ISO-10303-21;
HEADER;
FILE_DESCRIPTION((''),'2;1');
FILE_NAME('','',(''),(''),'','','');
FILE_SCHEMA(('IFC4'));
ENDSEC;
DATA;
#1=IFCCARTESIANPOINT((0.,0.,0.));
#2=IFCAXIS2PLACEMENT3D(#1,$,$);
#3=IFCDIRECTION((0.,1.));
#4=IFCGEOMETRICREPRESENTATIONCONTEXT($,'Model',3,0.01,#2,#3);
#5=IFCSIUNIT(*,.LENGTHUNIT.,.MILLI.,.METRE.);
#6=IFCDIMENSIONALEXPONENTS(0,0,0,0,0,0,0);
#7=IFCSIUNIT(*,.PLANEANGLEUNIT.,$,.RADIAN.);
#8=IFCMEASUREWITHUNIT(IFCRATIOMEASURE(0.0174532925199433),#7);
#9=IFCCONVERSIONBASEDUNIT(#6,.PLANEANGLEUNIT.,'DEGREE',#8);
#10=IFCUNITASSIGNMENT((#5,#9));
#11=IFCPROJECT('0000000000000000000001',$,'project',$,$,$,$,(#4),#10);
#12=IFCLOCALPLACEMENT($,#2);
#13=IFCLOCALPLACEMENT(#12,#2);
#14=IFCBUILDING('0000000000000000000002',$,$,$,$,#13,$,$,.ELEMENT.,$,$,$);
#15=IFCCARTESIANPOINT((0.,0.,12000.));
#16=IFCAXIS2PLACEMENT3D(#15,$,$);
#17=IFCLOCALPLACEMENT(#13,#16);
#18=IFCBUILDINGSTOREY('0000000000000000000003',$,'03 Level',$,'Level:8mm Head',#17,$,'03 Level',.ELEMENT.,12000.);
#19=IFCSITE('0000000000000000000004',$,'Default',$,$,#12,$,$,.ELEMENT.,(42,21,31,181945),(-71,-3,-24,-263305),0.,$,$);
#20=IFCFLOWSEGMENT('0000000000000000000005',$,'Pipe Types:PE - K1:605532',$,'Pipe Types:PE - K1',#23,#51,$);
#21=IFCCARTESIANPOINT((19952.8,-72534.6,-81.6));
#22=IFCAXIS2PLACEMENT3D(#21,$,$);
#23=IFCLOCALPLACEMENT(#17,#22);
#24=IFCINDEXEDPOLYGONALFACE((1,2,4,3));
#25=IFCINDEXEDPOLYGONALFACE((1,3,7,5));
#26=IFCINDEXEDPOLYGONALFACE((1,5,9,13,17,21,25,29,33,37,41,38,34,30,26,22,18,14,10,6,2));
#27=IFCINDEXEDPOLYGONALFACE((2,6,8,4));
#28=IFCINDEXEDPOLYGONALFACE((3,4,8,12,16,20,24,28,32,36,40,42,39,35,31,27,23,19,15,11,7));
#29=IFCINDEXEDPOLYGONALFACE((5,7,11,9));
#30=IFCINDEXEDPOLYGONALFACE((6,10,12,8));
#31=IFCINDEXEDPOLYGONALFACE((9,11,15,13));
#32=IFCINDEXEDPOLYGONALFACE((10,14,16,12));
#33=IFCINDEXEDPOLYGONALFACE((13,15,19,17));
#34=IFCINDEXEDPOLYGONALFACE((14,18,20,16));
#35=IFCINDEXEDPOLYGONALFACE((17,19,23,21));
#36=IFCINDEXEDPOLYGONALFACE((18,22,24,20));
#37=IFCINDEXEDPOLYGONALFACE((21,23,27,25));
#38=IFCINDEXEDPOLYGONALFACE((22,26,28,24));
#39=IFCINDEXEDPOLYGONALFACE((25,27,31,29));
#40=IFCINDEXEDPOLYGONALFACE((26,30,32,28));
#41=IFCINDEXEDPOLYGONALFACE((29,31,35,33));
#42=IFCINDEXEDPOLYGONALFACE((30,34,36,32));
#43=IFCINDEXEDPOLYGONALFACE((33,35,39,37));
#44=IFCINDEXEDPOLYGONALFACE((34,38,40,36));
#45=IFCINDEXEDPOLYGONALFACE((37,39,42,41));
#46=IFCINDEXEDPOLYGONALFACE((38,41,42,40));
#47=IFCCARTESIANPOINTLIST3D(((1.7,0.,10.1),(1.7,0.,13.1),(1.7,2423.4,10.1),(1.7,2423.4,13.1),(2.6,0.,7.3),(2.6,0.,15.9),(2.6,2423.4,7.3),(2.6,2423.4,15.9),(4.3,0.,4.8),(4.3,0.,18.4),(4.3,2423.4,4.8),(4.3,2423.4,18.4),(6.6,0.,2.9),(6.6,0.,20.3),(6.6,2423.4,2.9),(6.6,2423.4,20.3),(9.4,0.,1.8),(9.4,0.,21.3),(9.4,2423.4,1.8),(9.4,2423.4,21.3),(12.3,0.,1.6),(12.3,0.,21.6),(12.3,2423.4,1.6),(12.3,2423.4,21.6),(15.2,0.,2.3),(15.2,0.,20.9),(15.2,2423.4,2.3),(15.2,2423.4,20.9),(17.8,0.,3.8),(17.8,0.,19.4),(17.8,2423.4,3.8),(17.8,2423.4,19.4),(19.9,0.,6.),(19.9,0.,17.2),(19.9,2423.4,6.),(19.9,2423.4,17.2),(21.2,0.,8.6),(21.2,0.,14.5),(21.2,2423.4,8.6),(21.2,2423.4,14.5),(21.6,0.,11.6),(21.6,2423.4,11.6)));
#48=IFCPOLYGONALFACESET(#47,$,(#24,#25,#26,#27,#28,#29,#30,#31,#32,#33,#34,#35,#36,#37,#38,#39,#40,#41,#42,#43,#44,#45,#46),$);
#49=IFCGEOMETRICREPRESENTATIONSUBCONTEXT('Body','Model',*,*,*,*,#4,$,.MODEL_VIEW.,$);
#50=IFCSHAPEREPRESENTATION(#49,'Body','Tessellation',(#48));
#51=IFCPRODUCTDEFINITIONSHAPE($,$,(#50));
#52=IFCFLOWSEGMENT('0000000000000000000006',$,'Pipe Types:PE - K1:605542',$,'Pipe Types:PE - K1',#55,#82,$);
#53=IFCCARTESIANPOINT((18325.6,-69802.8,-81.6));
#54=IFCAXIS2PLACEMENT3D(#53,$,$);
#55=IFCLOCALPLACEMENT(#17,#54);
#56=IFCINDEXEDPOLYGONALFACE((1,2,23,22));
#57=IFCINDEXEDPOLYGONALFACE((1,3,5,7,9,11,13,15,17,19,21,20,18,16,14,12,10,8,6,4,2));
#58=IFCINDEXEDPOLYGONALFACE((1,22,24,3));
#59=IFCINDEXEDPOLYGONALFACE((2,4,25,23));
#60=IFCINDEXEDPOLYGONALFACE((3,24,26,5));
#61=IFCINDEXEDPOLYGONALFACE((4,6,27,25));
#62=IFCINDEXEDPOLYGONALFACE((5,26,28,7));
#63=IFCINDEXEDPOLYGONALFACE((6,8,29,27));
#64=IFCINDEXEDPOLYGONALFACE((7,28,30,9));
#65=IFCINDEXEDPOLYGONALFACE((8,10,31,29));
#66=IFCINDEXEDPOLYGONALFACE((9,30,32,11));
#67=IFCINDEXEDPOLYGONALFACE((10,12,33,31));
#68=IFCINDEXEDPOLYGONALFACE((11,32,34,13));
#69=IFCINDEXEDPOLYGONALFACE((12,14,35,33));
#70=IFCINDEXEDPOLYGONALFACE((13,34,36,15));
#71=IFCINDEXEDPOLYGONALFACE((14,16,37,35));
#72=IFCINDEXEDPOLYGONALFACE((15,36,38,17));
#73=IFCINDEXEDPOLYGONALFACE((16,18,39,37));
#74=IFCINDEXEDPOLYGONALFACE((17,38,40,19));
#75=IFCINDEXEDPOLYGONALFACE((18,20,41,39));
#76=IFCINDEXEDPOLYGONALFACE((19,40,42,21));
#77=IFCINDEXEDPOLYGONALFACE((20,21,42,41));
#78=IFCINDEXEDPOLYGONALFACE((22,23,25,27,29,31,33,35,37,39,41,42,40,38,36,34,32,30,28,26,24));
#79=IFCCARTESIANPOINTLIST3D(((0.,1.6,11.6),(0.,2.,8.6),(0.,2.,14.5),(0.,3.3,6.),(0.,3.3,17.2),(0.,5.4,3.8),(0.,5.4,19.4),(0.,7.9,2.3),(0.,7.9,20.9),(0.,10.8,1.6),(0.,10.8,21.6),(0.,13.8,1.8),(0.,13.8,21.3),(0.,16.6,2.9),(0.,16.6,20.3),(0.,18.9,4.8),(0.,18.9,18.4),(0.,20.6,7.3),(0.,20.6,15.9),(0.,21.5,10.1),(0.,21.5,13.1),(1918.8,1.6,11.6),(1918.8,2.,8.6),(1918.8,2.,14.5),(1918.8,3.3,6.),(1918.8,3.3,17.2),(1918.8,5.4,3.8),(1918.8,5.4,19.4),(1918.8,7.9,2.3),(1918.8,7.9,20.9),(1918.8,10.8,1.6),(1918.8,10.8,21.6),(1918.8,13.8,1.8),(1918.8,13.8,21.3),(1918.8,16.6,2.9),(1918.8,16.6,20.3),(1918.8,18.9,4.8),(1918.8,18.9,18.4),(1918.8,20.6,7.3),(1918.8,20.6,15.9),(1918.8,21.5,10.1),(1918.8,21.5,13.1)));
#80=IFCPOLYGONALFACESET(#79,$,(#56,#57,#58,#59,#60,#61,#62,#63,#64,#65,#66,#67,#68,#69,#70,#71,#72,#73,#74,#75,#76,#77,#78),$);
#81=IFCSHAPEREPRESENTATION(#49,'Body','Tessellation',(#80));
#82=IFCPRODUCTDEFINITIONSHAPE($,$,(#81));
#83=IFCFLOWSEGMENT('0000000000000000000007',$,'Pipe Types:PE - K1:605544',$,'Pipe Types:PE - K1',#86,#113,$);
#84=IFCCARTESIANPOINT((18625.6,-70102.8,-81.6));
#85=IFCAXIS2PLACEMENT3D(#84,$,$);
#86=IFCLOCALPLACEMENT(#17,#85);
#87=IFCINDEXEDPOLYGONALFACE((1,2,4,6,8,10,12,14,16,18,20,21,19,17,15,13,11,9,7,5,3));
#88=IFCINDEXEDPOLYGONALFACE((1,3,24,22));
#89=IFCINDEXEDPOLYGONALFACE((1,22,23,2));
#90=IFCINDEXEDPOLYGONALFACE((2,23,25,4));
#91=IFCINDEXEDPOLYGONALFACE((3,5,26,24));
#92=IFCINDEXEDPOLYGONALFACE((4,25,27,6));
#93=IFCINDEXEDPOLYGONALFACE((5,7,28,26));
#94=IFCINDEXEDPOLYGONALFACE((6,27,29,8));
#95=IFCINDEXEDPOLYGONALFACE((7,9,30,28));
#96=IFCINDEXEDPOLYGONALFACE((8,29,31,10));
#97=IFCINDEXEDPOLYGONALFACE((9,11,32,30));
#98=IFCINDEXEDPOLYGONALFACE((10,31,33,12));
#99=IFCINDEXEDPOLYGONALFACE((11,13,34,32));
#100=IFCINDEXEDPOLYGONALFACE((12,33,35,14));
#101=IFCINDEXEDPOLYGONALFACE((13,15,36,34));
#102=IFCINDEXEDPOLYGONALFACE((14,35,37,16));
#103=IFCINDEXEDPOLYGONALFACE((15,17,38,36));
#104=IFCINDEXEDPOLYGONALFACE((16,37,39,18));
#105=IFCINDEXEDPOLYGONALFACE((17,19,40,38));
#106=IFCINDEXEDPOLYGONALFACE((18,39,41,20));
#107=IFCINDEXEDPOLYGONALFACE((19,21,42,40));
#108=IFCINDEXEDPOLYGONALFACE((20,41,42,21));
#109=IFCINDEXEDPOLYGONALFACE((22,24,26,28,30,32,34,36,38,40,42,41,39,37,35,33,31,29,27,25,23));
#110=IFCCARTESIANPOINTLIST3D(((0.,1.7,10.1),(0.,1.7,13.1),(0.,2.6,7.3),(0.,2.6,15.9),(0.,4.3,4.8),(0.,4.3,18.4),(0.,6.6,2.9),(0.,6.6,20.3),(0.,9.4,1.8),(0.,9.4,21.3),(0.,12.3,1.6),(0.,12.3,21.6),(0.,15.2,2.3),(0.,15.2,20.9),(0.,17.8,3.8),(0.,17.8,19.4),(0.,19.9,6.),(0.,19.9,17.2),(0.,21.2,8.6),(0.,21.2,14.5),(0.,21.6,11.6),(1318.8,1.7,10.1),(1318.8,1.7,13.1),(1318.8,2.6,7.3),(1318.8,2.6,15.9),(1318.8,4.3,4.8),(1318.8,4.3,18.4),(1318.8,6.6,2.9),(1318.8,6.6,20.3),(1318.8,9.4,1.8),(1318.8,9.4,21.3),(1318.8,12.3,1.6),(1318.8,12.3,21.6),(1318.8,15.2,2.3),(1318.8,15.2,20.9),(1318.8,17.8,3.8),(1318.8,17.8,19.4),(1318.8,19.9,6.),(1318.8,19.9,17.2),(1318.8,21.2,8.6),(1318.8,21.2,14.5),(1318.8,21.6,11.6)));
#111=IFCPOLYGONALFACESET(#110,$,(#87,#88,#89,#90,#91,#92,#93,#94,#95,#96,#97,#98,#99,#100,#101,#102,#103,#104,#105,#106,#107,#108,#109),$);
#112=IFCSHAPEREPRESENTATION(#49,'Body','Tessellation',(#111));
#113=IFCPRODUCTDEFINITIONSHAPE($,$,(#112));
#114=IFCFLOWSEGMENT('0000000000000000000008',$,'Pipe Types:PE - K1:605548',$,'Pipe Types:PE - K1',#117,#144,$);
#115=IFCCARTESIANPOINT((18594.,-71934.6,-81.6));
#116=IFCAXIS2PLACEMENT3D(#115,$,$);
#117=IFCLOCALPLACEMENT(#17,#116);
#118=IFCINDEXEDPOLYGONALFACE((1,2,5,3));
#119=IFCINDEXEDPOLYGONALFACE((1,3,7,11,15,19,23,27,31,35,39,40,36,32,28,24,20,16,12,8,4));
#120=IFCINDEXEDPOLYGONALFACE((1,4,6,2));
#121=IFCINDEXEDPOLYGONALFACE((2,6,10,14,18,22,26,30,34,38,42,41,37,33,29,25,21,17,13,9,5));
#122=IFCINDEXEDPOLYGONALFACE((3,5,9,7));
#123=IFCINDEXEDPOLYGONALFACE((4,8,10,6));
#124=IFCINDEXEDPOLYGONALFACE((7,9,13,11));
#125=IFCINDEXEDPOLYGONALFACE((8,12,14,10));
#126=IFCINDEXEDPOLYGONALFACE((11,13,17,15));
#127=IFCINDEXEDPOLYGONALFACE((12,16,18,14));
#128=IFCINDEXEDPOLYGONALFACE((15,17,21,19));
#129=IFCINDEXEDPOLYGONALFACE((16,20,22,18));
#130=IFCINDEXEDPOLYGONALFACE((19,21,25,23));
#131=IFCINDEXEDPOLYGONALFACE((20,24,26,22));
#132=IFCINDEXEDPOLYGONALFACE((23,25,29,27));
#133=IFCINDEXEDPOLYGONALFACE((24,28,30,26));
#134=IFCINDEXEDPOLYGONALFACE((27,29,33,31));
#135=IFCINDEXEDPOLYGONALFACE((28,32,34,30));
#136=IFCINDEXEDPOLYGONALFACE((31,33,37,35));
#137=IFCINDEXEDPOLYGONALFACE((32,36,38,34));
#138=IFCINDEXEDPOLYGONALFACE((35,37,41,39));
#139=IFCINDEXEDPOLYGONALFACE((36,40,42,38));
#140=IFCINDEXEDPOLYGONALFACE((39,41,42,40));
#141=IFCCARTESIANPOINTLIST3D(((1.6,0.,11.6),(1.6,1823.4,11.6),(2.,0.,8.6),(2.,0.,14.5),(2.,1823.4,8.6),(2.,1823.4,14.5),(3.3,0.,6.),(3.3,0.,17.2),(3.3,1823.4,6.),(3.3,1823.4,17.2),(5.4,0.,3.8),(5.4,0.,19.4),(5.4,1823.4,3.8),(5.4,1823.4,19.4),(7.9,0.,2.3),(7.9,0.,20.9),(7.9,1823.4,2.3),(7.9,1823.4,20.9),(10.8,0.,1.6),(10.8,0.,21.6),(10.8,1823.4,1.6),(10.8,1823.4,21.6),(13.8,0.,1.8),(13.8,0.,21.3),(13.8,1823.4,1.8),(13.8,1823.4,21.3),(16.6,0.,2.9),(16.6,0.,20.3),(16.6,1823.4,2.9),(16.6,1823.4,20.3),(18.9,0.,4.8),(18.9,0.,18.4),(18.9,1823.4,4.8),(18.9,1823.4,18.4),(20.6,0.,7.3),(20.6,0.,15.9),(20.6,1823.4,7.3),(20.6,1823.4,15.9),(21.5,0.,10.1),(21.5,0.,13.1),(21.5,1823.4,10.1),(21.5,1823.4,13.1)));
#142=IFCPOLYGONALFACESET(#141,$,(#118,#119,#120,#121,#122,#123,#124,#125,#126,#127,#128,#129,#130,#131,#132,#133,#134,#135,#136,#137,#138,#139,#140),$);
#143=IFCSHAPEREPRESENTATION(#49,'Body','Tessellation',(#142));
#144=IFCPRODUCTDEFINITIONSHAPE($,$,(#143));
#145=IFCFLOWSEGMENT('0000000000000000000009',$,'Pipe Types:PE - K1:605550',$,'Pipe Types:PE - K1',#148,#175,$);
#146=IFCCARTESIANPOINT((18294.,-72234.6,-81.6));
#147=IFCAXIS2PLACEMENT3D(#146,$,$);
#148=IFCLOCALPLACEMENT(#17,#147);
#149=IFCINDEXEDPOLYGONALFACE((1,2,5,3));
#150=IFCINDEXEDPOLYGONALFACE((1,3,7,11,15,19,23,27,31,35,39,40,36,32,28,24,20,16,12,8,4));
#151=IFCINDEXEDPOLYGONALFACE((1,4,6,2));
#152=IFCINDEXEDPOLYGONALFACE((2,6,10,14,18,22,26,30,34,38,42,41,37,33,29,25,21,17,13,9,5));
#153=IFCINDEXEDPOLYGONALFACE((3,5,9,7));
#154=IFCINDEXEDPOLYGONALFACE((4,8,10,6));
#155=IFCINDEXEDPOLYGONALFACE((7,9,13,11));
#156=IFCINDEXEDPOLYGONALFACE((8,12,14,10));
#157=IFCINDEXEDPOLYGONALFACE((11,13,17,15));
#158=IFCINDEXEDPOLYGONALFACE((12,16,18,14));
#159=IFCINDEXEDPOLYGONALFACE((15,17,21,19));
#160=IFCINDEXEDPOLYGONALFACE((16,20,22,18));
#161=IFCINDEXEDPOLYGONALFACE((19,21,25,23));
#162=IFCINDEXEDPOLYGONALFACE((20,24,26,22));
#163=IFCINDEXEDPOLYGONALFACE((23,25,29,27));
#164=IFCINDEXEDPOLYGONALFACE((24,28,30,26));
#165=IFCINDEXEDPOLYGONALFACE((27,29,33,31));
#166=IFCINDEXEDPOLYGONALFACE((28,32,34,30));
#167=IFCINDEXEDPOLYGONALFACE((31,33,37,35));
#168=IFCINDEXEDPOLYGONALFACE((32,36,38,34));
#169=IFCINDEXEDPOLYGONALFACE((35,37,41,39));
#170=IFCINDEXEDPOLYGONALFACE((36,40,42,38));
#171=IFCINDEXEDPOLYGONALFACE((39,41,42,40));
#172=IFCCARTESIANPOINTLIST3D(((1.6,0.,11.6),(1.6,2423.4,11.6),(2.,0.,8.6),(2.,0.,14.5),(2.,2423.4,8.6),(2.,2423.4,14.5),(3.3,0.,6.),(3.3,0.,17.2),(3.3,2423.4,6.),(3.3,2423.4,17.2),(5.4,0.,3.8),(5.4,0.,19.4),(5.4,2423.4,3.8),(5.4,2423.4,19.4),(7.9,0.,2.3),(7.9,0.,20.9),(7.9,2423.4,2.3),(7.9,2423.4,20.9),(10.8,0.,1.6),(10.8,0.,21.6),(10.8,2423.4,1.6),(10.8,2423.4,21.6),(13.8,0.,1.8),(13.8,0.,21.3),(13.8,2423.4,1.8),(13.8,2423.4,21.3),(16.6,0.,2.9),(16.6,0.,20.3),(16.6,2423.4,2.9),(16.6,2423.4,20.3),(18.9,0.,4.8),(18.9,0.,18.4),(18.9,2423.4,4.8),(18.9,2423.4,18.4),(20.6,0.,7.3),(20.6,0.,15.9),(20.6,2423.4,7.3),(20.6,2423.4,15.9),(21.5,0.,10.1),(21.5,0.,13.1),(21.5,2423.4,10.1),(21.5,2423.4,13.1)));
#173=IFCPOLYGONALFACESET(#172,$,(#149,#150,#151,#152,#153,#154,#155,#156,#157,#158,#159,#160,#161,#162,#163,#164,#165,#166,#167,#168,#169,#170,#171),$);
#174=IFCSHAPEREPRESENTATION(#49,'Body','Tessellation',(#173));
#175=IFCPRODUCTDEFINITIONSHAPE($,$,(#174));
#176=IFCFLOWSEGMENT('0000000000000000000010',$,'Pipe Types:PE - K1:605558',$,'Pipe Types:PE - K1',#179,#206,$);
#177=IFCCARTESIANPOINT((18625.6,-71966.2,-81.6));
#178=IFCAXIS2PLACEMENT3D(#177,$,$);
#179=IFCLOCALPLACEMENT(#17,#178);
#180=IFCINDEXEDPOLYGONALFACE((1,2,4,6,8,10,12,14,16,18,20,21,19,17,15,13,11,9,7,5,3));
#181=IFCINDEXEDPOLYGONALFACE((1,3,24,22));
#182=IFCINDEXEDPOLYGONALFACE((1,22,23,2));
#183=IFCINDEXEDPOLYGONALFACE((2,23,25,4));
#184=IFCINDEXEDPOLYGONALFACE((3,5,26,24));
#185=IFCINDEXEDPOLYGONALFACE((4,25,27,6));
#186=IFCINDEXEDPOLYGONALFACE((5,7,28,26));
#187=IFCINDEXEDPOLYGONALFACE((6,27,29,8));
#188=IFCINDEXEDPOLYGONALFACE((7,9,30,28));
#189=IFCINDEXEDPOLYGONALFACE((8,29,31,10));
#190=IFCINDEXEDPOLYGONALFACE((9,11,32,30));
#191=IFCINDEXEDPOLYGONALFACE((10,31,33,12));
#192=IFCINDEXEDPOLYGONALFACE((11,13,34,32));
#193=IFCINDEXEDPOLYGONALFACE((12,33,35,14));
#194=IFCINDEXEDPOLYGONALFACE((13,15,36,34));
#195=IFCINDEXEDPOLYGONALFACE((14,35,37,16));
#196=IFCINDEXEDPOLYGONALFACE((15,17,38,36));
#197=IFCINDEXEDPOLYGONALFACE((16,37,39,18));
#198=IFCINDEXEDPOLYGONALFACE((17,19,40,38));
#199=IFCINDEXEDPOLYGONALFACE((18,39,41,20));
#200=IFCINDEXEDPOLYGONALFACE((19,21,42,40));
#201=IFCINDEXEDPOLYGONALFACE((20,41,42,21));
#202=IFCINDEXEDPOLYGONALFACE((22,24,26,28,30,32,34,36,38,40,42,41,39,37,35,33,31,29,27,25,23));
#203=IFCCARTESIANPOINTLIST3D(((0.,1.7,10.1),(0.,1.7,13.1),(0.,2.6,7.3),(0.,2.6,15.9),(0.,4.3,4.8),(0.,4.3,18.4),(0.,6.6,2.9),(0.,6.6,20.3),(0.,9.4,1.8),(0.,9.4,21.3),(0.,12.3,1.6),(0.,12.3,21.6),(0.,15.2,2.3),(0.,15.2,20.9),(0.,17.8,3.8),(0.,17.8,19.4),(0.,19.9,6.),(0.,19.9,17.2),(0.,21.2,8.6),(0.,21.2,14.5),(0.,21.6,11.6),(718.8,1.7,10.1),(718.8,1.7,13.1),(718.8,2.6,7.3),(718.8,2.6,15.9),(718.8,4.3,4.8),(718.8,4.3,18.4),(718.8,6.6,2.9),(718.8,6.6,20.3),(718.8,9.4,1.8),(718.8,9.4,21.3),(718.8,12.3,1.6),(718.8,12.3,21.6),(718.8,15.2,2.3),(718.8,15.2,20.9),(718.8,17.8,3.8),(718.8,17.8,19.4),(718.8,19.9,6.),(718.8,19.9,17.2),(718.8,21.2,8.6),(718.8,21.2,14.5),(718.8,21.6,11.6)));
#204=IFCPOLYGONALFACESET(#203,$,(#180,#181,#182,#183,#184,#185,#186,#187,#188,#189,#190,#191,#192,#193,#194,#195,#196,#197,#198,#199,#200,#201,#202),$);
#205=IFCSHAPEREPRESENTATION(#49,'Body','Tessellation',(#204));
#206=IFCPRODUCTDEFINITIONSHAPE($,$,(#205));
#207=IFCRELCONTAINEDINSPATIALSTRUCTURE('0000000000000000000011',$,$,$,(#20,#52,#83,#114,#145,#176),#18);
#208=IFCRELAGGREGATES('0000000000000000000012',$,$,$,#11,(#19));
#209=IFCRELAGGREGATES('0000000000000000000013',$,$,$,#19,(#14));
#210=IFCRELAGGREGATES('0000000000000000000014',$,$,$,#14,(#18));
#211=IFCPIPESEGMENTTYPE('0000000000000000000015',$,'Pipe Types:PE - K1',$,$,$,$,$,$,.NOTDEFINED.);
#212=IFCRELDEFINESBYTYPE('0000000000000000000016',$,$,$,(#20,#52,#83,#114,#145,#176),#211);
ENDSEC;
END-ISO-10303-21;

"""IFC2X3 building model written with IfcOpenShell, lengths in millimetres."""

from ifc_helpers import new_model, entity, si_unit, converted_unit, direction, frame, frame_2d, origin, origin_2d_with_axis, place, context, subcontext, project, spatial, circle, extrude, type_object, element, save


model = new_model("IFC2X3")

# Units and contexts
model_context = context("Model", 3, precision=0.01, world=origin(), true_north=direction((0.0, 1.0)))
body_context = subcontext(model_context, "Body", "Model", "MODEL_VIEW")
ifc_project = project(units=[si_unit("LENGTHUNIT", "METRE", prefix="MILLI"), converted_unit("PLANEANGLEUNIT", "DEGREE", entity("IfcRatioMeasure", 0.0174532925199433), si_unit("PLANEANGLEUNIT", "RADIAN"), dimensions=[0, 0, 0, 0, 0, 0, 0])], contexts=[model_context])

# Site, building, storey
site_placement = place(None, origin())
site = spatial("IfcSite", under=ifc_project, at=site_placement, Name="Default", CompositionType="ELEMENT", RefLatitude=(42, 21, 31, 181945), RefLongitude=(-71, -3, -24, -263305), RefElevation=0.0)
building_placement = place(site_placement, origin())
building = spatial("IfcBuilding", under=site, at=building_placement, CompositionType="ELEMENT")
storey_placement = place(building_placement, frame((0.0, 0.0, 12000.0)))
storey = spatial("IfcBuildingStorey", under=building, at=storey_placement, Name="03 Level", ObjectType="Level:8mm Head", LongName="03 Level", CompositionType="ELEMENT", Elevation=12000.0)

# Flow segments
pipe_segment_type = type_object("IfcPipeSegmentType", Name="Pipe Types:PE - K1", PredefinedType="NOTDEFINED")
flow_segment_1_placement = place(storey_placement, frame((19952.8, -72534.6, -81.6)))
element("IfcFlowSegment", 1, at=flow_segment_1_placement, inside=storey, type_object=pipe_segment_type, Name="Pipe Types:PE - K1:605532", ObjectType="Pipe Types:PE - K1", context=body_context, shape_type="SweptSolid", body=[
    extrude(circle(Radius=10.0, at=origin_2d_with_axis()), frame((11.6, 0.0, 11.6), z_axis=(0.0, 1.0, 0.0), x_axis=(1.0, 0.0, 0.0)), (0.0, 0.0, 1.0), 2423.4),
])
flow_segment_2_placement = place(storey_placement, frame((18325.6, -69802.8, -81.6)))
element("IfcFlowSegment", 2, at=flow_segment_2_placement, inside=storey, type_object=pipe_segment_type, Name="Pipe Types:PE - K1:605542", ObjectType="Pipe Types:PE - K1", context=body_context, shape_type="SweptSolid", body=[
    extrude(circle(Radius=10.0, at=origin_2d_with_axis()), frame((0.0, 11.6, 11.6), z_axis=(1.0, 0.0, 0.0), x_axis=(0.0, -1.0, 0.0)), (0.0, 0.0, 1.0), 1918.8),
])
flow_segment_3_placement = place(storey_placement, frame((18625.6, -70102.8, -81.6)))
element("IfcFlowSegment", 3, at=flow_segment_3_placement, inside=storey, type_object=pipe_segment_type, Name="Pipe Types:PE - K1:605544", ObjectType="Pipe Types:PE - K1", context=body_context, shape_type="SweptSolid", body=[
    extrude(circle(Radius=10.0, at=frame_2d((0.0, 0.0), x_axis=(1.0, 0.0))), frame((0.0, 11.6, 11.6), z_axis=(1.0, 0.0, 0.0), x_axis=(0.0, 1.0, 0.0)), (0.0, 0.0, 1.0), 1318.8),
])
flow_segment_4_placement = place(storey_placement, frame((18594.0, -71934.6, -81.6)))
element("IfcFlowSegment", 4, at=flow_segment_4_placement, inside=storey, type_object=pipe_segment_type, Name="Pipe Types:PE - K1:605548", ObjectType="Pipe Types:PE - K1", context=body_context, shape_type="SweptSolid", body=[
    extrude(circle(Radius=10.0, at=frame_2d((0.0, 0.0), x_axis=(1.0, 0.0))), frame((11.6, 0.0, 11.6), z_axis=(0.0, 1.0, 0.0), x_axis=(-1.0, 0.0, 0.0)), (0.0, 0.0, 1.0), 1823.4),
])
flow_segment_5_placement = place(storey_placement, frame((18294.0, -72234.6, -81.6)))
element("IfcFlowSegment", 5, at=flow_segment_5_placement, inside=storey, type_object=pipe_segment_type, Name="Pipe Types:PE - K1:605550", ObjectType="Pipe Types:PE - K1", context=body_context, shape_type="SweptSolid", body=[
    extrude(circle(Radius=10.0, at=frame_2d((0.0, 0.0), x_axis=(1.0, 0.0))), frame((11.6, 0.0, 11.6), z_axis=(0.0, 1.0, 0.0), x_axis=(-1.0, 0.0, 0.0)), (0.0, 0.0, 1.0), 2423.4),
])
flow_segment_6_placement = place(storey_placement, frame((18625.6, -71966.2, -81.6)))
element("IfcFlowSegment", 6, at=flow_segment_6_placement, inside=storey, type_object=pipe_segment_type, Name="Pipe Types:PE - K1:605558", ObjectType="Pipe Types:PE - K1", context=body_context, shape_type="SweptSolid", body=[
    extrude(circle(Radius=10.0, at=origin_2d_with_axis()), frame((0.0, 11.6, 11.6), z_axis=(1.0, 0.0, 0.0), x_axis=(0.0, 1.0, 0.0)), (0.0, 0.0, 1.0), 718.8),
])

save(model, "model.ifc")
